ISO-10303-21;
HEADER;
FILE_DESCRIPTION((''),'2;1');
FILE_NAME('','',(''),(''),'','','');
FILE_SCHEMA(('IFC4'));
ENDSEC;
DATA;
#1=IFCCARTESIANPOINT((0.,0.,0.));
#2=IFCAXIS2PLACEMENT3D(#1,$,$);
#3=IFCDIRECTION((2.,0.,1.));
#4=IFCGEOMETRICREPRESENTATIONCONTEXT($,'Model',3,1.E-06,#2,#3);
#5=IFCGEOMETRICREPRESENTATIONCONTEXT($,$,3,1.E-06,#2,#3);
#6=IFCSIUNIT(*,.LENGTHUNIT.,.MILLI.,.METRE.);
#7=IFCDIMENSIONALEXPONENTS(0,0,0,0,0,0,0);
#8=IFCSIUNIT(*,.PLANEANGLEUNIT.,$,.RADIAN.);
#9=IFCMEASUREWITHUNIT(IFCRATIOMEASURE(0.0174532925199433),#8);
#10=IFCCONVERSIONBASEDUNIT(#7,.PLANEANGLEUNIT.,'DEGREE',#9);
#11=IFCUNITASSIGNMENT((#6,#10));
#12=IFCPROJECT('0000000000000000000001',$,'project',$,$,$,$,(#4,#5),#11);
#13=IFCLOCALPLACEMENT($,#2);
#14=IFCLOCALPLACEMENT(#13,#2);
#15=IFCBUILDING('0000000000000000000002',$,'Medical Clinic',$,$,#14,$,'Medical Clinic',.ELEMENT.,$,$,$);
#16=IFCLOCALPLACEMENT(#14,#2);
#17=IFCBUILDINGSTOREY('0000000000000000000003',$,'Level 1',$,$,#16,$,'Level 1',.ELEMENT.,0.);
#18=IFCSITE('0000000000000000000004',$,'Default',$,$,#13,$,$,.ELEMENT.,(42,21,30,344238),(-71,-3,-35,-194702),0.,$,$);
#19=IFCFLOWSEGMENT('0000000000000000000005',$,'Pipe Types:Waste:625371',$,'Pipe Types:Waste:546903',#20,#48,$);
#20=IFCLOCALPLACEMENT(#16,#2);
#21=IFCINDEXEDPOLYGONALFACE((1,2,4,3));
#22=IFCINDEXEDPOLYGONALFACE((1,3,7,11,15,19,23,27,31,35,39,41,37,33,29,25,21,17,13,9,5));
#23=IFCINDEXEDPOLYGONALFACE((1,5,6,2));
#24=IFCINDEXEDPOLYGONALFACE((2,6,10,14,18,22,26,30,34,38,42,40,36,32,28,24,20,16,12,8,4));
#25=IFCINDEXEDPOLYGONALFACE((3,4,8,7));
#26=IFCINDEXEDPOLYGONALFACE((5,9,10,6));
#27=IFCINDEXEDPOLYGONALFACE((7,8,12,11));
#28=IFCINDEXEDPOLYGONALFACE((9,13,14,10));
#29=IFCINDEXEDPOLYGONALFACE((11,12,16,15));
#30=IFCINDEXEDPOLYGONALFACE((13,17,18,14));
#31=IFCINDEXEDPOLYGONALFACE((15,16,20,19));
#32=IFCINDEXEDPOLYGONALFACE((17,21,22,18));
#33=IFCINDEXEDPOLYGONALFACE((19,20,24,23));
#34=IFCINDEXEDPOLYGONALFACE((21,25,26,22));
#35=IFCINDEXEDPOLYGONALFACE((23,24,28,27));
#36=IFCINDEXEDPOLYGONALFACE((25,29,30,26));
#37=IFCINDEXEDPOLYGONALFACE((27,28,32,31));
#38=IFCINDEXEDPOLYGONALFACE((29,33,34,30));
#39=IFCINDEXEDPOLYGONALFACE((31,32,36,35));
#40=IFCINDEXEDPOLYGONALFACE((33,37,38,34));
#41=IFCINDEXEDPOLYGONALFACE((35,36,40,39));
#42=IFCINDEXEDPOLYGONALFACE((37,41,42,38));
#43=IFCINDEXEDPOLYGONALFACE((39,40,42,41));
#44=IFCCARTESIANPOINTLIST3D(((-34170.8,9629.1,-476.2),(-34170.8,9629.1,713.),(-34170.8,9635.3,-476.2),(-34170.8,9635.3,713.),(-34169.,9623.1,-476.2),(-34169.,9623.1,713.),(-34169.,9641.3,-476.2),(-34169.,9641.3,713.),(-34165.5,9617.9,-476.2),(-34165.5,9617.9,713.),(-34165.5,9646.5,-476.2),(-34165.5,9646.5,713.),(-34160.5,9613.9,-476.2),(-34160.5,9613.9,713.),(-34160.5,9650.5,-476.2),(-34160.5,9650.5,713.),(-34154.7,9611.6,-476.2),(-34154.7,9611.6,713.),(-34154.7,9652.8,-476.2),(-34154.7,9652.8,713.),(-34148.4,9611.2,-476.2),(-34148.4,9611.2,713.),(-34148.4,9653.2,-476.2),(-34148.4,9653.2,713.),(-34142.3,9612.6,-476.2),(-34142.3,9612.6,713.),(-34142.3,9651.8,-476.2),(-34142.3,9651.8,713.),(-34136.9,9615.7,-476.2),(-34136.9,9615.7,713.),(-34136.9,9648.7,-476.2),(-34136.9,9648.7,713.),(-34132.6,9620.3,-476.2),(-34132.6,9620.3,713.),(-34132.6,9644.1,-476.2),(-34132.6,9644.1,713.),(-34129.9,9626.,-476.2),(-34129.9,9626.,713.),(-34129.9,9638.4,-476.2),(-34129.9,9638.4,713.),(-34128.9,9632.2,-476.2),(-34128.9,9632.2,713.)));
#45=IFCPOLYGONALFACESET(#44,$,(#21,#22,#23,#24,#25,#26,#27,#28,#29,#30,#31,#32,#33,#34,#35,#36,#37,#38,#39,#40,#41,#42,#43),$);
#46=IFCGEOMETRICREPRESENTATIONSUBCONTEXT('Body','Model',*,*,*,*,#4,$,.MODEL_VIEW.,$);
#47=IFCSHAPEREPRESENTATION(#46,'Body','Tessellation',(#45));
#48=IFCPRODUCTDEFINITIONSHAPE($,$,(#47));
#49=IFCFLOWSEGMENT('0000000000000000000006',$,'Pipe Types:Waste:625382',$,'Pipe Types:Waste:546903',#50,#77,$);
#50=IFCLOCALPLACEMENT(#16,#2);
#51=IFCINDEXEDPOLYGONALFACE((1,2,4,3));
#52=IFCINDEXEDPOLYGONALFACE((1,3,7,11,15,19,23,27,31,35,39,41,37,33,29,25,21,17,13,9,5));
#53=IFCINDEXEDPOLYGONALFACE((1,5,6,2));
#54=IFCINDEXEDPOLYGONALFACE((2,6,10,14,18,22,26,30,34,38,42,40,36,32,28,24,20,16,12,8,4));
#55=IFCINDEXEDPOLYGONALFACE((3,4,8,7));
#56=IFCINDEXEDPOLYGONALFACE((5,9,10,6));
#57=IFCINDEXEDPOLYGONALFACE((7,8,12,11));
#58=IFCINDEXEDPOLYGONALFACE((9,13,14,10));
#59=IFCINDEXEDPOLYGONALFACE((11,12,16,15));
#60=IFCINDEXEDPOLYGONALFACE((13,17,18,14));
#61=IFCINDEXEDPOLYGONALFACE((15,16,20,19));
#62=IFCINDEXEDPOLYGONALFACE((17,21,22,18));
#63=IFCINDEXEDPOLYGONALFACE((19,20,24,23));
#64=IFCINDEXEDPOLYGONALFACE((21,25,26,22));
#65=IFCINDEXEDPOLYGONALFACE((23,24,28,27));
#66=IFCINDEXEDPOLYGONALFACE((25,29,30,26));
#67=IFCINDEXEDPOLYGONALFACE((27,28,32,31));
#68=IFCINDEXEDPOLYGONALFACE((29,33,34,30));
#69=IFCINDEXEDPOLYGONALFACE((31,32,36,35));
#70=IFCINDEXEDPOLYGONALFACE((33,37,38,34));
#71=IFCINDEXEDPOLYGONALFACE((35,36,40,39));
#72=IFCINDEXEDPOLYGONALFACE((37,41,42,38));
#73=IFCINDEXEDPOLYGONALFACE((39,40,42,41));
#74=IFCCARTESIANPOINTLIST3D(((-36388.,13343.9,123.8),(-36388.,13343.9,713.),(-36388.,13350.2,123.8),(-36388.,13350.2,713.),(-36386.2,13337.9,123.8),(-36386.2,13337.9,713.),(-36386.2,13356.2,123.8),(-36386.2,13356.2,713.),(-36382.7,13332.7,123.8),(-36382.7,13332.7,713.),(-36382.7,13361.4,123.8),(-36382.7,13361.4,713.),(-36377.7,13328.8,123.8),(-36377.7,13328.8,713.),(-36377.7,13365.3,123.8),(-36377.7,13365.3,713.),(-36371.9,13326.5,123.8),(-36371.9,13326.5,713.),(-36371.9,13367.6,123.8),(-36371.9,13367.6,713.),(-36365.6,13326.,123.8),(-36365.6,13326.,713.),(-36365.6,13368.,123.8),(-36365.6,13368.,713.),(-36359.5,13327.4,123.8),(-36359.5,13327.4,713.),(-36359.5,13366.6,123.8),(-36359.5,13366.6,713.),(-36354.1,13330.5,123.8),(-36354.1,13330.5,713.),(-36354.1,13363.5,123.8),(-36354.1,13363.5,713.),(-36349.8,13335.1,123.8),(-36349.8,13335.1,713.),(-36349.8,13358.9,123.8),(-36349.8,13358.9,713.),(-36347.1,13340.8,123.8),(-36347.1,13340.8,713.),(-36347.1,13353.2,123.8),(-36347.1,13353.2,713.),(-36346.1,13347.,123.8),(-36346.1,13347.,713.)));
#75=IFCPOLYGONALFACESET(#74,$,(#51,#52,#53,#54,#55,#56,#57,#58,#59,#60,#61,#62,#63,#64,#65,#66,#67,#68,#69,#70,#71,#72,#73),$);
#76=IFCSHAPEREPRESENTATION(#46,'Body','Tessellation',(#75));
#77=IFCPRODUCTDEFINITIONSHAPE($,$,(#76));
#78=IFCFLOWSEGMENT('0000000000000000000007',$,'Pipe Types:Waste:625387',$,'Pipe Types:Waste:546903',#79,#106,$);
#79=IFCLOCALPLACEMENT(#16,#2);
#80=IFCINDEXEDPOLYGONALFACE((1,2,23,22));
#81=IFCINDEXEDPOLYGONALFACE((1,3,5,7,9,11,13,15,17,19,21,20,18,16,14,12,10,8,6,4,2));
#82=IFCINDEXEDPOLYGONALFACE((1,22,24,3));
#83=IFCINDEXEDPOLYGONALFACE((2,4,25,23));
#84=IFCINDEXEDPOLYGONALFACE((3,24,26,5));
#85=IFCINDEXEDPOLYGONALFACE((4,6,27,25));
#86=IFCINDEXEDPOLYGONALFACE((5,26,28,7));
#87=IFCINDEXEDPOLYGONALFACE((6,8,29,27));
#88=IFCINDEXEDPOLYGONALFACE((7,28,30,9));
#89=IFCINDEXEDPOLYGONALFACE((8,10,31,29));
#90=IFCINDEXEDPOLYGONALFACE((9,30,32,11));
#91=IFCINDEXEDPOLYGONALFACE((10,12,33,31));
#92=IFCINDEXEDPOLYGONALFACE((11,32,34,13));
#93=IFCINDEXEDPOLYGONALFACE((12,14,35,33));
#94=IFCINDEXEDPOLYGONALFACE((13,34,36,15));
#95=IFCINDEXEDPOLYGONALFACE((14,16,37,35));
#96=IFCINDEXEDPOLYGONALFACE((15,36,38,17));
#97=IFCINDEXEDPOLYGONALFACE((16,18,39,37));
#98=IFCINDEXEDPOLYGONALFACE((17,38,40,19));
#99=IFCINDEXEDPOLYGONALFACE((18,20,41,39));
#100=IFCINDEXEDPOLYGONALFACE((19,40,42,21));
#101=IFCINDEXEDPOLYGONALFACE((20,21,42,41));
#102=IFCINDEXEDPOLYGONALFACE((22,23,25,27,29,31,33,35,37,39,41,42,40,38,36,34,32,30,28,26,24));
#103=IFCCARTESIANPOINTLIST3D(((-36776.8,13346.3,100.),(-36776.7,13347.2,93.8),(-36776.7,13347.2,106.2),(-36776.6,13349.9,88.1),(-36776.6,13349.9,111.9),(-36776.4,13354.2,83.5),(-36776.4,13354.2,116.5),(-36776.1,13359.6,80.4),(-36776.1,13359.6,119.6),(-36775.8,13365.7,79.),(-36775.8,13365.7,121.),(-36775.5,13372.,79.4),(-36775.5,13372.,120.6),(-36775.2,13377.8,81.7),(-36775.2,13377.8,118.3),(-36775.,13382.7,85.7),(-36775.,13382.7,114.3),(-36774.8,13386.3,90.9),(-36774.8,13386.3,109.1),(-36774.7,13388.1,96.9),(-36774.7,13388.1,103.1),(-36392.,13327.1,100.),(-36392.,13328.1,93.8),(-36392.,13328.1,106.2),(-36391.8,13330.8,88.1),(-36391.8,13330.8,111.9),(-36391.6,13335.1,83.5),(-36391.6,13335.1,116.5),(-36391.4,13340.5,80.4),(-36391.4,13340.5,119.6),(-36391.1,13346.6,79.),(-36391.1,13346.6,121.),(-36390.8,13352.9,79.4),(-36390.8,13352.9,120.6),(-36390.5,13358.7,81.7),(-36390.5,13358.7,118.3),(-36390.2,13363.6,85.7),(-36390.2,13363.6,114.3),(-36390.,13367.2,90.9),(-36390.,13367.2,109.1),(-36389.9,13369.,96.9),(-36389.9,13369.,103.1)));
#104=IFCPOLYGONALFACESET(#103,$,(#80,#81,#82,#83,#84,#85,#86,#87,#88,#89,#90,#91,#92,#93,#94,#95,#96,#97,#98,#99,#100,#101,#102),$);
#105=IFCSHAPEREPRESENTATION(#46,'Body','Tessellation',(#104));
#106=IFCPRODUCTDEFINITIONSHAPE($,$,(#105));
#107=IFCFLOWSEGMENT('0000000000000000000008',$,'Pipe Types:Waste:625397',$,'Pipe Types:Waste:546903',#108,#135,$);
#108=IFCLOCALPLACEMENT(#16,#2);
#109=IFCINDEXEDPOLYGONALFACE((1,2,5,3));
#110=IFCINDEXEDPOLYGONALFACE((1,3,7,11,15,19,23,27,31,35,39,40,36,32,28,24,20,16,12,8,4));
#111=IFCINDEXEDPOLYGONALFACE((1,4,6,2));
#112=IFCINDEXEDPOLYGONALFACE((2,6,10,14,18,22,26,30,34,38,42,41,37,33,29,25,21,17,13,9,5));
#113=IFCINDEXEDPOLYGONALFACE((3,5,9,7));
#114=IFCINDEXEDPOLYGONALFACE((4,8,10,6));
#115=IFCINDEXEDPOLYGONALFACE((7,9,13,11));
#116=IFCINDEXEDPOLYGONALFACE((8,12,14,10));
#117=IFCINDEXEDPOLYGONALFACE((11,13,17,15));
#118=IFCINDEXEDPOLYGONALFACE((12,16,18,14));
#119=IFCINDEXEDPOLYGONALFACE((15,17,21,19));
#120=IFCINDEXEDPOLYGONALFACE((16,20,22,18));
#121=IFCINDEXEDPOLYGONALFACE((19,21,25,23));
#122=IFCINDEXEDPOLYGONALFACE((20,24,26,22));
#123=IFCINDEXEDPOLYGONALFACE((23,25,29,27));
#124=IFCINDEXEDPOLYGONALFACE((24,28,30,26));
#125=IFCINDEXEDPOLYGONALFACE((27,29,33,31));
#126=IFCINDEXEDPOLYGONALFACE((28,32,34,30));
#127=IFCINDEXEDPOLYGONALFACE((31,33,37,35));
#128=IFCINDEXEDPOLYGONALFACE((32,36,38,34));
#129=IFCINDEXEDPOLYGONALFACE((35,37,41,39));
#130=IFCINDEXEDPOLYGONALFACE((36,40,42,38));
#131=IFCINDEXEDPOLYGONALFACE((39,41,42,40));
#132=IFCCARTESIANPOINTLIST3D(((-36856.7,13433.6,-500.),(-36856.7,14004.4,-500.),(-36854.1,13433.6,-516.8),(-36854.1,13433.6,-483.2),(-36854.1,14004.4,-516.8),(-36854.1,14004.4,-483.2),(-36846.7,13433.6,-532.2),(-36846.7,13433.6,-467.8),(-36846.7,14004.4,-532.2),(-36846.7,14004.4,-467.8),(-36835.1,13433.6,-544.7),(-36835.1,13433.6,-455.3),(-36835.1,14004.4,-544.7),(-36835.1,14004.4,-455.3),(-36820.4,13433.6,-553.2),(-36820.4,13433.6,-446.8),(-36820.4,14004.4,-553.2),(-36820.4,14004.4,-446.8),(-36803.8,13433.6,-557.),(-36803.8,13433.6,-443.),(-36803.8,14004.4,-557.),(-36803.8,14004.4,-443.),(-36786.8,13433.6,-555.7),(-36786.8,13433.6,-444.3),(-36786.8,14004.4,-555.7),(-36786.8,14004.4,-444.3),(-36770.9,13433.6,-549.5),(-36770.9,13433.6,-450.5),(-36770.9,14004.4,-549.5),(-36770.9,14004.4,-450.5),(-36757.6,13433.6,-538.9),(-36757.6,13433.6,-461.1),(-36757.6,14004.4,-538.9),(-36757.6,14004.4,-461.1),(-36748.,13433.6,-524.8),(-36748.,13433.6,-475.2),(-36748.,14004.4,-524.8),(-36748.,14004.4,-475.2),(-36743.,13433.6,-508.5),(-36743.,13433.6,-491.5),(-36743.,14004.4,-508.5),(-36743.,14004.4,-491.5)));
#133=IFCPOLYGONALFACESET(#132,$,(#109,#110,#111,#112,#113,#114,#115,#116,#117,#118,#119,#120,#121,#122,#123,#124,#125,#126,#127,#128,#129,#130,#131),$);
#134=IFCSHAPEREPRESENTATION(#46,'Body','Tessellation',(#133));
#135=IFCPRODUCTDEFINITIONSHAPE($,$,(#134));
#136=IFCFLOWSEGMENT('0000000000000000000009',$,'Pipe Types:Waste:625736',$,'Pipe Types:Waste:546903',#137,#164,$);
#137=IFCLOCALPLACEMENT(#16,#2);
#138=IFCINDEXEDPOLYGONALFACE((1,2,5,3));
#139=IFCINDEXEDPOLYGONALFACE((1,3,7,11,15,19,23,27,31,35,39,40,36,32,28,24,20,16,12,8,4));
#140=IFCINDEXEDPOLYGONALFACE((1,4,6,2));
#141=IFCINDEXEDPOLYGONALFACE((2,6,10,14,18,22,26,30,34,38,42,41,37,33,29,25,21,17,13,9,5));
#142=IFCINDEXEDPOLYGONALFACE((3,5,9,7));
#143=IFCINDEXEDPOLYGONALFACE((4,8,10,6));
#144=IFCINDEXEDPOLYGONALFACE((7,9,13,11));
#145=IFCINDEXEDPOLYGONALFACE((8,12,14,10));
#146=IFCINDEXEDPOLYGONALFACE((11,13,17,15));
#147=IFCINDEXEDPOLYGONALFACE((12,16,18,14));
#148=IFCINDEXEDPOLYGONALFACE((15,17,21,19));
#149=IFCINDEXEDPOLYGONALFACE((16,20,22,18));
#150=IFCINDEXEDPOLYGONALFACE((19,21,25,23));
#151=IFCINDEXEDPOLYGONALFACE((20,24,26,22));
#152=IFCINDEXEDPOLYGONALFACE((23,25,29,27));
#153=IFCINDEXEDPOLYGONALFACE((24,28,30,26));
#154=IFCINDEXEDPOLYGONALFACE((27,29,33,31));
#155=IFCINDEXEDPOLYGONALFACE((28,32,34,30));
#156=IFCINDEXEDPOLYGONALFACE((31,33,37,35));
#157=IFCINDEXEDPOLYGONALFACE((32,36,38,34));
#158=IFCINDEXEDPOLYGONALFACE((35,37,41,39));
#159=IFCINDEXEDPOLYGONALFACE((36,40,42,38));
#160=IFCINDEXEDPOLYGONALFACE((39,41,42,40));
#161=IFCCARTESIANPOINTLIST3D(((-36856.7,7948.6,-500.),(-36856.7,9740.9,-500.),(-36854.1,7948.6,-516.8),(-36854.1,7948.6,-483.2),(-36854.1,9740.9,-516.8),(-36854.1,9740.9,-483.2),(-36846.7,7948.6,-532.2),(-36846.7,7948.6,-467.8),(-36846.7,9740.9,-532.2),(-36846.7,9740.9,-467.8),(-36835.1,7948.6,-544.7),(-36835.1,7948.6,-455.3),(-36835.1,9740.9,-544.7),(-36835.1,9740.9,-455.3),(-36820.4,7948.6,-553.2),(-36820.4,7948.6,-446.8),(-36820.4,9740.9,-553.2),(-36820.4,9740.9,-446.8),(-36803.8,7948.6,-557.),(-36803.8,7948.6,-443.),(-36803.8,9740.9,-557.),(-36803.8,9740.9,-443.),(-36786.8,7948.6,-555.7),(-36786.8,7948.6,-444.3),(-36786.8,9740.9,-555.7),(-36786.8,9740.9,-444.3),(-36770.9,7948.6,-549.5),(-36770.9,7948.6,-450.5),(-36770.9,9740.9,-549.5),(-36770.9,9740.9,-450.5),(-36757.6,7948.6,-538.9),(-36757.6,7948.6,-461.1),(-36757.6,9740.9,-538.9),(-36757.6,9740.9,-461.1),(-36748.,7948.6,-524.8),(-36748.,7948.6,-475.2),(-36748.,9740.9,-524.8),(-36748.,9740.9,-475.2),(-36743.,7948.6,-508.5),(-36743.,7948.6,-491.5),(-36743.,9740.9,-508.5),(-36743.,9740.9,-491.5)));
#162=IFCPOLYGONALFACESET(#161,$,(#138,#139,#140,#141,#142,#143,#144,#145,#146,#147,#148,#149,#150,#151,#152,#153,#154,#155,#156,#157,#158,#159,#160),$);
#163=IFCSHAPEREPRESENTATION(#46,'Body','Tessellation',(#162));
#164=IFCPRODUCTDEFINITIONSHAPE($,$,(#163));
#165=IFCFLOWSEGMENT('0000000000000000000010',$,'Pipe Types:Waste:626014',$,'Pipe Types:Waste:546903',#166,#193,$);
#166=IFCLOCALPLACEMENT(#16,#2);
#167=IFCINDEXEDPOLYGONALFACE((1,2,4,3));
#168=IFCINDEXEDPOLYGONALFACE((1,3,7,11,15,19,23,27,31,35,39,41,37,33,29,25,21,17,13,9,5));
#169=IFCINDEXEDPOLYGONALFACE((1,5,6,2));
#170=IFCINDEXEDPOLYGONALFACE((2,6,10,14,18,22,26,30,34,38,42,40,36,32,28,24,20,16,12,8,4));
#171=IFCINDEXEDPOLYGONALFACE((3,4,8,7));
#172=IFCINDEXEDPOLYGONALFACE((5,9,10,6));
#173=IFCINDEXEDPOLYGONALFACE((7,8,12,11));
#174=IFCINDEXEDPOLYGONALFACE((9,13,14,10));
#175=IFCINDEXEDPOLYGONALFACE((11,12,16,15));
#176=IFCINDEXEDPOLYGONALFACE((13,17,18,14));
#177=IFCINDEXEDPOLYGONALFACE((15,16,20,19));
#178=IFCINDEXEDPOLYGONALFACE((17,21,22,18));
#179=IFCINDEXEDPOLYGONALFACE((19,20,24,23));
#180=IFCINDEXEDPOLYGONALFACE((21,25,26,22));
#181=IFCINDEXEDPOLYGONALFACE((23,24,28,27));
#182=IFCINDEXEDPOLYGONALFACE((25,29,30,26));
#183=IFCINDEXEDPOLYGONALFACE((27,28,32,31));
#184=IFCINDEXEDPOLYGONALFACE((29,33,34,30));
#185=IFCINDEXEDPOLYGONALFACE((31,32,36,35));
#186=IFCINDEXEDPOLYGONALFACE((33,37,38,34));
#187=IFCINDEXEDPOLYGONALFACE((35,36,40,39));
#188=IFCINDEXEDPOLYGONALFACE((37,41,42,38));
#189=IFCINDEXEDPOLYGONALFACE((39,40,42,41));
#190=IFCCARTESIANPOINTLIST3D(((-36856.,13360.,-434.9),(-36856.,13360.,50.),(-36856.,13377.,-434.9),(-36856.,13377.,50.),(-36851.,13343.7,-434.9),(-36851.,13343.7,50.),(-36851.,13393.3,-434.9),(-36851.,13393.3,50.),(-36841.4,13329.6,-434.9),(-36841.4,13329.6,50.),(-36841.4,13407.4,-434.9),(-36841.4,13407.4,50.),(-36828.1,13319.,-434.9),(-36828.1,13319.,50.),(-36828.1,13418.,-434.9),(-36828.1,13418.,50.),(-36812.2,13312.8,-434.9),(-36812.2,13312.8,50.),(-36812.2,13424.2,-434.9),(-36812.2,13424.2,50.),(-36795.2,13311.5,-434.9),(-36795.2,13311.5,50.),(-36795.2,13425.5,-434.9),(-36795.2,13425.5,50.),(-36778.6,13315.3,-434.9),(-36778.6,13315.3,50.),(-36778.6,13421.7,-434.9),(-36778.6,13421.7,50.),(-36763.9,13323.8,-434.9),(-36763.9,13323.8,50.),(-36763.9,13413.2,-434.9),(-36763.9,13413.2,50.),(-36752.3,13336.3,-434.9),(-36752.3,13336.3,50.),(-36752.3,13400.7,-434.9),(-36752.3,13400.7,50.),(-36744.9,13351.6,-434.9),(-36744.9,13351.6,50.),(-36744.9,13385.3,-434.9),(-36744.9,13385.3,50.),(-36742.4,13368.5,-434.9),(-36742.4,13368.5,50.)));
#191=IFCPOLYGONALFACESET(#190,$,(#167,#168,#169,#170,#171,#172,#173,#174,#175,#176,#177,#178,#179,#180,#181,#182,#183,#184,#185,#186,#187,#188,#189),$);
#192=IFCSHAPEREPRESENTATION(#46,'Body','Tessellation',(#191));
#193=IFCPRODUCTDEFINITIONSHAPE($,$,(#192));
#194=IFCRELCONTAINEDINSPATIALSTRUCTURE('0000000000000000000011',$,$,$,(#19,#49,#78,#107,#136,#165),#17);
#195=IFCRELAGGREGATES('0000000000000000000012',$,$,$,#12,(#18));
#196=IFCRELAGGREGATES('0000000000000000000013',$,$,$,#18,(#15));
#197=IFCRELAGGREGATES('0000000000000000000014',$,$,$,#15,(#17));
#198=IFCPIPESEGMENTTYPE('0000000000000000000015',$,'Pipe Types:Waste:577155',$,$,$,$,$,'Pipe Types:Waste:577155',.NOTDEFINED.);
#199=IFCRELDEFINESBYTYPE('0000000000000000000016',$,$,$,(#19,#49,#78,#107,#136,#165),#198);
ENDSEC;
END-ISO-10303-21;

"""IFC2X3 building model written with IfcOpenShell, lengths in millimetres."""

from ifc_helpers import new_model, entity, si_unit, converted_unit, direction, frame, frame_2d, origin, origin_2d_with_axis, place, context, subcontext, project, spatial, circle, extrude, type_object, element, save


model = new_model("IFC2X3")

# Units and contexts
model_context = context("Model", 3, precision=1e-06, world=origin(), true_north=direction((2.0, 0.0, 1.0)))
context_of_model = context(None, 3, precision=1e-06, world=origin(), true_north=direction((2.0, 0.0, 1.0)))
body_context = subcontext(model_context, "Body", "Model", "MODEL_VIEW")
ifc_project = project(units=[si_unit("LENGTHUNIT", "METRE", prefix="MILLI"), converted_unit("PLANEANGLEUNIT", "DEGREE", entity("IfcRatioMeasure", 0.0174532925199433), si_unit("PLANEANGLEUNIT", "RADIAN"), dimensions=[0, 0, 0, 0, 0, 0, 0])], contexts=[model_context, context_of_model])

# Site, building, storey
site_placement = place(None, origin())
site = spatial("IfcSite", under=ifc_project, at=site_placement, Name="Default", CompositionType="ELEMENT", RefLatitude=(42, 21, 30, 344238), RefLongitude=(-71, -3, -35, -194702), RefElevation=0.0)
building_placement = place(site_placement, origin())
building = spatial("IfcBuilding", under=site, at=building_placement, Name="Medical Clinic", LongName="Medical Clinic", CompositionType="ELEMENT")
storey_placement = place(building_placement, origin())
storey = spatial("IfcBuildingStorey", under=building, at=storey_placement, Name="Level 1", LongName="Level 1", CompositionType="ELEMENT", Elevation=0.0)

# Flow segments
pipe_segment_type = type_object("IfcPipeSegmentType", Name="Pipe Types:Waste:577155", ElementType="Pipe Types:Waste:577155", PredefinedType="NOTDEFINED")
flow_segment_1_placement = place(storey_placement, origin())
element("IfcFlowSegment", 1, at=flow_segment_1_placement, inside=storey, type_object=pipe_segment_type, Name="Pipe Types:Waste:625371", ObjectType="Pipe Types:Waste:546903", context=body_context, shape_type="SweptSolid", body=[
    extrude(circle(Radius=21.1, at=origin_2d_with_axis()), frame((-34150.0, 9632.2, -476.2)), (0.0, 0.0, 1.0), 1189.2),
])
flow_segment_2_placement = place(storey_placement, origin())
element("IfcFlowSegment", 2, at=flow_segment_2_placement, inside=storey, type_object=pipe_segment_type, Name="Pipe Types:Waste:625382", ObjectType="Pipe Types:Waste:546903", context=body_context, shape_type="SweptSolid", body=[
    extrude(circle(Radius=21.1, at=origin_2d_with_axis()), frame((-36367.2, 13347.0, 123.8)), (0.0, 0.0, 1.0), 589.2),
])
flow_segment_3_placement = place(storey_placement, origin())
element("IfcFlowSegment", 3, at=flow_segment_3_placement, inside=storey, type_object=pipe_segment_type, Name="Pipe Types:Waste:625387", ObjectType="Pipe Types:Waste:546903", context=body_context, shape_type="SweptSolid", body=[
    extrude(circle(Radius=21.1, at=frame_2d((0.0, 0.0), x_axis=(1.0, 0.0))), frame((-36775.7, 13367.3, 100.0), z_axis=(0.998768, -0.049622, 0.0), x_axis=(-0.049622, -0.998768, 0.0)), (0.0, 0.0, 1.0), 385.2),
])
flow_segment_4_placement = place(storey_placement, origin())
element("IfcFlowSegment", 4, at=flow_segment_4_placement, inside=storey, type_object=pipe_segment_type, Name="Pipe Types:Waste:625397", ObjectType="Pipe Types:Waste:546903", context=body_context, shape_type="SweptSolid", body=[
    extrude(circle(Radius=57.1, at=origin_2d_with_axis()), frame((-36799.5, 13433.6, -500.0), z_axis=(0.0, 1.0, 0.0), x_axis=(-1.0, 0.0, 0.0)), (0.0, 0.0, 1.0), 570.9),
])
flow_segment_5_placement = place(storey_placement, origin())
element("IfcFlowSegment", 5, at=flow_segment_5_placement, inside=storey, type_object=pipe_segment_type, Name="Pipe Types:Waste:625736", ObjectType="Pipe Types:Waste:546903", context=body_context, shape_type="SweptSolid", body=[
    extrude(circle(Radius=57.1, at=frame_2d((0.0, 0.0), x_axis=(1.0, 0.0))), frame((-36799.5, 7948.6, -500.0), z_axis=(0.0, 1.0, 0.0), x_axis=(-1.0, 0.0, 0.0)), (0.0, 0.0, 1.0), 1792.3),
])
flow_segment_6_placement = place(storey_placement, origin())
element("IfcFlowSegment", 6, at=flow_segment_6_placement, inside=storey, type_object=pipe_segment_type, Name="Pipe Types:Waste:626014", ObjectType="Pipe Types:Waste:546903", context=body_context, shape_type="SweptSolid", body=[
    extrude(circle(Radius=57.1, at=origin_2d_with_axis()), frame((-36799.5, 13368.5, -434.9)), (0.0, 0.0, 1.0), 484.9),
])

save(model, "model.ifc")
